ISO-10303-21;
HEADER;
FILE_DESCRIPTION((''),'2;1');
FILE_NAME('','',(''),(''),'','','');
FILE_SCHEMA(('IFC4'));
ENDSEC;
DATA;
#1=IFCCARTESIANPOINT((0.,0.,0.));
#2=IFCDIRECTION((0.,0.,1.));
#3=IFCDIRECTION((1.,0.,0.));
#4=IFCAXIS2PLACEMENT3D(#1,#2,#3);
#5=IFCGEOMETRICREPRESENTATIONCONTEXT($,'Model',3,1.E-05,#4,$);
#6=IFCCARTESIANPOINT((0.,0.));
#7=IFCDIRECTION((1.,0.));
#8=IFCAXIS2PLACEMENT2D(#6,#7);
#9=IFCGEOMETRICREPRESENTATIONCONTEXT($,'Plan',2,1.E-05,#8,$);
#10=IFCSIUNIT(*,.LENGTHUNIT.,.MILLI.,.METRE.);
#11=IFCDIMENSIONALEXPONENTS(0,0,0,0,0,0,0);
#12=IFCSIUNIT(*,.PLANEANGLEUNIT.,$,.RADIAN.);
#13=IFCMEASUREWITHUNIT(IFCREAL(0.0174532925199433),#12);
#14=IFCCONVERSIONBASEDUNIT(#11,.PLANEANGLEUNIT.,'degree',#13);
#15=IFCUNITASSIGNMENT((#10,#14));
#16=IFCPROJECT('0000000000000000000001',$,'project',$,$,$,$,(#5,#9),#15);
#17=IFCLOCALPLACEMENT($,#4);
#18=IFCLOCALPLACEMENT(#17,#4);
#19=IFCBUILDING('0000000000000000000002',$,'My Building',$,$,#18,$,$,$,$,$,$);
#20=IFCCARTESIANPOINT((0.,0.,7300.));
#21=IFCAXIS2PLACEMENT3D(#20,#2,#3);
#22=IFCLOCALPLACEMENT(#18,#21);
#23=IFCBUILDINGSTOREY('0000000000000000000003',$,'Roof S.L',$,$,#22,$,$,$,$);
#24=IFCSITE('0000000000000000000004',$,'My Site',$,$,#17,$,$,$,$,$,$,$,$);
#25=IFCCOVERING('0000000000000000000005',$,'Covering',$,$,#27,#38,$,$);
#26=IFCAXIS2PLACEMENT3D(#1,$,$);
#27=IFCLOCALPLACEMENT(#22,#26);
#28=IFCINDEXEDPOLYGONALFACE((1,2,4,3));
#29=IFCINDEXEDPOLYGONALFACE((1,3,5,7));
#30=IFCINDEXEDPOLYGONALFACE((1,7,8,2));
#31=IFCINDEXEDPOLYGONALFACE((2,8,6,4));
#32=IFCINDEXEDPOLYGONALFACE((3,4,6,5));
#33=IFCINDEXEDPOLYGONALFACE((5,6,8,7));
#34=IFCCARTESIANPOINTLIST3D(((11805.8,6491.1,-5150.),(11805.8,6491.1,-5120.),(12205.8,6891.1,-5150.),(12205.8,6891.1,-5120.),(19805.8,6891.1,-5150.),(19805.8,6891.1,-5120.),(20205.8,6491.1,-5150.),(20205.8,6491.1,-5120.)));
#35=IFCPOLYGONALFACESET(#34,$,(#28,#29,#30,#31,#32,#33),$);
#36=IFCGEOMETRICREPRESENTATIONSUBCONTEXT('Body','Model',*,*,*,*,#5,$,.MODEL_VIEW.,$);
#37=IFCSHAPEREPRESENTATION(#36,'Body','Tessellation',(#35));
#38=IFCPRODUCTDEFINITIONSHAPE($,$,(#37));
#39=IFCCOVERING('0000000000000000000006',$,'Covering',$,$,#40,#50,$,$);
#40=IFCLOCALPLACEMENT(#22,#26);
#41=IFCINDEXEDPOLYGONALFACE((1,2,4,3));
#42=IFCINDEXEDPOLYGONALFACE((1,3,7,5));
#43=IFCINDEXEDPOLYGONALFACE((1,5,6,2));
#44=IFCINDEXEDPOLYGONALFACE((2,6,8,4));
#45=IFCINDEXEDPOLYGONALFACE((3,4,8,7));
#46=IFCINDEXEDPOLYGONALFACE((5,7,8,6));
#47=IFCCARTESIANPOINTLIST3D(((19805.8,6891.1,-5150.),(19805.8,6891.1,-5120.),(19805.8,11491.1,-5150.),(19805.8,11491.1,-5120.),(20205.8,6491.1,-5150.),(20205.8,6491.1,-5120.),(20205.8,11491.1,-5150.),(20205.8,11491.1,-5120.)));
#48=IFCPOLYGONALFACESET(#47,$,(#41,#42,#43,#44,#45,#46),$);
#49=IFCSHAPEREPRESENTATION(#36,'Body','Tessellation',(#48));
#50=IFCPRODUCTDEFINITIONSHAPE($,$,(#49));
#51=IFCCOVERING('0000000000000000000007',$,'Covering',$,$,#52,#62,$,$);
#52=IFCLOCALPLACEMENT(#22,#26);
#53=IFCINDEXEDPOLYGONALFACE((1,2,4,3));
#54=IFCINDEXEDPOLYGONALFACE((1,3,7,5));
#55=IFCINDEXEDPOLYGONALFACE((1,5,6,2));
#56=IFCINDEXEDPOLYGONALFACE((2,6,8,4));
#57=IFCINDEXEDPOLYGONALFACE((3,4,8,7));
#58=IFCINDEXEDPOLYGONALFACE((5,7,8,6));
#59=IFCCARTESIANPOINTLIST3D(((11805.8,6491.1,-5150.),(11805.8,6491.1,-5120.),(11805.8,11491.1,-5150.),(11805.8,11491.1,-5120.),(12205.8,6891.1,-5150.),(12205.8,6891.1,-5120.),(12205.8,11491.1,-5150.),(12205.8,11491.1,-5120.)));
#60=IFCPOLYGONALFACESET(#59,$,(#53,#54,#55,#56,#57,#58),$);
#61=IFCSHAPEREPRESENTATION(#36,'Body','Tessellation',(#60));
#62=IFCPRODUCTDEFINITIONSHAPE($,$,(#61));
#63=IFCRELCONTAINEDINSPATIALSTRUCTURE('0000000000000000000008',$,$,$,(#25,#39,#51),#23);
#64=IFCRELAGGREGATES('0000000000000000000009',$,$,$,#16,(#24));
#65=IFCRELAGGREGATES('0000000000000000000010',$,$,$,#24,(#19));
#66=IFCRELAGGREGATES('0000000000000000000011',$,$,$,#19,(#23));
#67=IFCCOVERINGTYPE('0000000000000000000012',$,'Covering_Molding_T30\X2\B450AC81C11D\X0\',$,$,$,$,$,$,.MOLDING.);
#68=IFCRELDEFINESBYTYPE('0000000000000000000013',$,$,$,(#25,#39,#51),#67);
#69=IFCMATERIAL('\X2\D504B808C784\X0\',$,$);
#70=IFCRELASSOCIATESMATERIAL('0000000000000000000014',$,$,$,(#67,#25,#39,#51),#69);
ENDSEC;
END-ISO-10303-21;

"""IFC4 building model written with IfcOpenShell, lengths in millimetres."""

from ifc_helpers import new_model, entity, si_unit, converted_unit, frame, origin_with_axes, origin_2d_with_axis, place, context, subcontext, project, spatial, rectangle, extrude, clip, halfspace, material, material_profile, profile_set, profile_usage, type_object, element, save


model = new_model("IFC4")

# Units and contexts
model_context = context("Model", 3, precision=1e-05, world=origin_with_axes())
plan_context = context("Plan", 2, precision=1e-05, world=origin_2d_with_axis())
body_context = subcontext(model_context, "Body", "Model", "MODEL_VIEW")
ifc_project = project(units=[si_unit("LENGTHUNIT", "METRE", prefix="MILLI"), converted_unit("PLANEANGLEUNIT", "degree", entity("IfcReal", 0.0174532925199433), si_unit("PLANEANGLEUNIT", "RADIAN"), dimensions=[0, 0, 0, 0, 0, 0, 0])], contexts=[model_context, plan_context])

# Site, building, storey
site_placement = place(None, origin_with_axes())
site = spatial("IfcSite", under=ifc_project, at=site_placement, Name="My Site")
building_placement = place(site_placement, origin_with_axes())
building = spatial("IfcBuilding", under=site, at=building_placement, Name="My Building")
storey_placement = place(building_placement, frame((0.0, 0.0, 7300.0), z_axis=(0.0, 0.0, 1.0), x_axis=(1.0, 0.0, 0.0)))
storey = spatial("IfcBuildingStorey", under=building, at=storey_placement, Name="Roof S.L")

# Coverings
ifc_material_1 = material(Name="프레임")
ifc_material_profile = material_profile(ifc_material_1, rectangle(XDim=400.0, YDim=30.0, kind="CURVE"))
ifc_profile_set = profile_set([ifc_material_profile])
covering_type = type_object("IfcCoveringType", Name="Covering_Molding_T30두겁석", PredefinedType="MOLDING", material=ifc_profile_set)
ifc_profile_usage_1 = profile_usage(ifc_profile_set, cardinal=5)
covering_1_placement = place(storey_placement, frame((11805.8, 6691.1, -5135.0), z_axis=(1.0, 0.0, 0.0), x_axis=(0.0, 1.0, 0.0)))
element("IfcCovering", 1, at=covering_1_placement, inside=storey, type_object=covering_type, material=ifc_profile_usage_1, Name="Covering", context=body_context, shape_type="Clipping", body=[
    clip(clip(extrude(rectangle(XDim=400.0, YDim=30.0, kind="CURVE"), origin_with_axes(), (0.0, 0.0, 1.0), 8400.0), halfspace(frame((-200.0, -2165.0, 8400.0), z_axis=(0.707109, 0.0, 0.707105), x_axis=(0.0, -1.0, 0.0)), False)), halfspace(frame((-200.0, -2165.0, 0.0), z_axis=(0.707108, 0.0, -0.707106), x_axis=(0.0, -1.0, 0.0)), False)),
])
ifc_profile_usage_2 = profile_usage(ifc_profile_set, cardinal=5)
covering_2_placement = place(storey_placement, frame((20005.8, 6491.1, -5135.0), z_axis=(0.0, 1.0, 0.0), x_axis=(-1.0, 0.0, 0.0)))
element("IfcCovering", 2, at=covering_2_placement, inside=storey, type_object=covering_type, material=ifc_profile_usage_2, Name="Covering", context=body_context, shape_type="Clipping", body=[
    clip(extrude(rectangle(XDim=400.0, YDim=30.0, kind="CURVE"), origin_with_axes(), (0.0, 0.0, 1.0), 5000.0), halfspace(frame((-200.0, -2165.0, 0.0), z_axis=(0.707105, 0.0, -0.707109), x_axis=(0.0, -1.0, 0.0)), False)),
])
ifc_profile_usage_3 = profile_usage(ifc_profile_set, cardinal=5)
covering_3_placement = place(storey_placement, frame((12005.8, 6491.1, -5135.0), z_axis=(0.0, 1.0, 0.0), x_axis=(-1.0, 0.0, 0.0)))
element("IfcCovering", 3, at=covering_3_placement, inside=storey, type_object=covering_type, material=ifc_profile_usage_3, Name="Covering", context=body_context, shape_type="Clipping", body=[
    clip(extrude(rectangle(XDim=400.0, YDim=30.0, kind="CURVE"), origin_with_axes(), (0.0, 0.0, 1.0), 5000.0), halfspace(frame((200.0, -2165.0, 0.0), z_axis=(-0.707106, 0.0, -0.707107), x_axis=(0.0, 1.0, 0.0)), False)),
])

save(model, "model.ifc")
